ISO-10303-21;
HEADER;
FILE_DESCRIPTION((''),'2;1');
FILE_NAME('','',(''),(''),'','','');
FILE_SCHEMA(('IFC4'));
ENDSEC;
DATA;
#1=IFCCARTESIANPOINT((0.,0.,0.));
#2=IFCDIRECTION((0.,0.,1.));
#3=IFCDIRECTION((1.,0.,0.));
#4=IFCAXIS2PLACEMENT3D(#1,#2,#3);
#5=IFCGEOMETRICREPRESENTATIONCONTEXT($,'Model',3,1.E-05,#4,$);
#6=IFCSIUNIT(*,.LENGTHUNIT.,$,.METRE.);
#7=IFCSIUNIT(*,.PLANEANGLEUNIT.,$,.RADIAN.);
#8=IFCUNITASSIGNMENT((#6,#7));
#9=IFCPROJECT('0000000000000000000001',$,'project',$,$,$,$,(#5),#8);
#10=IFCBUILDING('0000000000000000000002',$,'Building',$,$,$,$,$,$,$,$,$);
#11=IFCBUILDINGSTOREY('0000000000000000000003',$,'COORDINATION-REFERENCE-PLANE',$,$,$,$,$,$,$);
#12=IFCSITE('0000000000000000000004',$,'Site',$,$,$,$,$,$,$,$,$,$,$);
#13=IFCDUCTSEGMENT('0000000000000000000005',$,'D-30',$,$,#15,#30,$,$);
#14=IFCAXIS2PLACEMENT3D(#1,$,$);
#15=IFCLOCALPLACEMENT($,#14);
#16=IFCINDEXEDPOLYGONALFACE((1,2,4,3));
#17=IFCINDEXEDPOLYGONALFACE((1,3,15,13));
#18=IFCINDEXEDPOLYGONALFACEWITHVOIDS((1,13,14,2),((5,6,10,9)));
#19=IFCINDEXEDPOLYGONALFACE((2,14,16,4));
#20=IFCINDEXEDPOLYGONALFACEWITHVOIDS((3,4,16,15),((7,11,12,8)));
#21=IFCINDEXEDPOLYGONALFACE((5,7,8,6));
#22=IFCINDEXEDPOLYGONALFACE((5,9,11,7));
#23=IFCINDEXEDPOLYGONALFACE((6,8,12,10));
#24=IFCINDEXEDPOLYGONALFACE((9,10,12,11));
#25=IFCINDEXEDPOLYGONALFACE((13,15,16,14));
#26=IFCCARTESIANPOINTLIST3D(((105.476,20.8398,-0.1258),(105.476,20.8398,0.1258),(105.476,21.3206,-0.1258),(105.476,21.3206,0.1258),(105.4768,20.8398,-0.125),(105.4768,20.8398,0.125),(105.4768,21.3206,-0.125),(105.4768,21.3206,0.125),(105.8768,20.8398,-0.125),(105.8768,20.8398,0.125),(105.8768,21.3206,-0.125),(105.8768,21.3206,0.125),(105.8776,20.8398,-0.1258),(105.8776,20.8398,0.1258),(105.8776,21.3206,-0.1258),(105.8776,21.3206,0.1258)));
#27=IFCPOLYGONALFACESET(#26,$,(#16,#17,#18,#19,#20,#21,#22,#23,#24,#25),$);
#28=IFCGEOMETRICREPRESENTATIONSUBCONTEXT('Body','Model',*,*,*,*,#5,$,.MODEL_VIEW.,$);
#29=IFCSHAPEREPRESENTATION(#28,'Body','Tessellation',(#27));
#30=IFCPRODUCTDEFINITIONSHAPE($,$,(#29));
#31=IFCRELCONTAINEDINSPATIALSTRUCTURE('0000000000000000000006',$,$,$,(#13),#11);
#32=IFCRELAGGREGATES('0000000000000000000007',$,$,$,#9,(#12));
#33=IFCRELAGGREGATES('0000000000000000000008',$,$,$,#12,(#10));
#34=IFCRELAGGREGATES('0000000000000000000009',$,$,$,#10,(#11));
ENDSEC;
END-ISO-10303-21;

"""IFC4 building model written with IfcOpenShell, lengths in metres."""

from ifc_helpers import new_model, si_unit, frame, origin, origin_with_axes, place, context, subcontext, project, spatial, hollow_rectangle, extrude, element, save


model = new_model("IFC4")

# Units and contexts
model_context_1 = context("Model", 3, precision=1e-05, world=origin_with_axes())
body_context_1 = subcontext(model_context_1, "Body", "Model", "MODEL_VIEW")
ifc_project = project(units=[si_unit("LENGTHUNIT", "METRE"), si_unit("PLANEANGLEUNIT", "RADIAN")], contexts=[model_context_1])

# Site, building, storey
site = spatial("IfcSite", under=ifc_project, Name="Site")
building = spatial("IfcBuilding", under=site, Name="Building")
storey = spatial("IfcBuildingStorey", under=building, Name="COORDINATION-REFERENCE-PLANE")

# Duct segment
duct_segment_1_placement = place(None, frame((105.6768, 20.8398, 0.0), z_axis=(0.0, 1.0, 0.0), x_axis=(1.0, 0.0, 0.0)))
element("IfcDuctSegment", 1, at=duct_segment_1_placement, inside=storey, Name="D-30", context=body_context_1, shape_type="SweptSolid", body=[
    extrude(hollow_rectangle(XDim=0.4016, YDim=0.2516, WallThickness=0.0008), origin(), (0.0, 0.0, 1.0), 0.4808),
])

save(model, "model.ifc")
